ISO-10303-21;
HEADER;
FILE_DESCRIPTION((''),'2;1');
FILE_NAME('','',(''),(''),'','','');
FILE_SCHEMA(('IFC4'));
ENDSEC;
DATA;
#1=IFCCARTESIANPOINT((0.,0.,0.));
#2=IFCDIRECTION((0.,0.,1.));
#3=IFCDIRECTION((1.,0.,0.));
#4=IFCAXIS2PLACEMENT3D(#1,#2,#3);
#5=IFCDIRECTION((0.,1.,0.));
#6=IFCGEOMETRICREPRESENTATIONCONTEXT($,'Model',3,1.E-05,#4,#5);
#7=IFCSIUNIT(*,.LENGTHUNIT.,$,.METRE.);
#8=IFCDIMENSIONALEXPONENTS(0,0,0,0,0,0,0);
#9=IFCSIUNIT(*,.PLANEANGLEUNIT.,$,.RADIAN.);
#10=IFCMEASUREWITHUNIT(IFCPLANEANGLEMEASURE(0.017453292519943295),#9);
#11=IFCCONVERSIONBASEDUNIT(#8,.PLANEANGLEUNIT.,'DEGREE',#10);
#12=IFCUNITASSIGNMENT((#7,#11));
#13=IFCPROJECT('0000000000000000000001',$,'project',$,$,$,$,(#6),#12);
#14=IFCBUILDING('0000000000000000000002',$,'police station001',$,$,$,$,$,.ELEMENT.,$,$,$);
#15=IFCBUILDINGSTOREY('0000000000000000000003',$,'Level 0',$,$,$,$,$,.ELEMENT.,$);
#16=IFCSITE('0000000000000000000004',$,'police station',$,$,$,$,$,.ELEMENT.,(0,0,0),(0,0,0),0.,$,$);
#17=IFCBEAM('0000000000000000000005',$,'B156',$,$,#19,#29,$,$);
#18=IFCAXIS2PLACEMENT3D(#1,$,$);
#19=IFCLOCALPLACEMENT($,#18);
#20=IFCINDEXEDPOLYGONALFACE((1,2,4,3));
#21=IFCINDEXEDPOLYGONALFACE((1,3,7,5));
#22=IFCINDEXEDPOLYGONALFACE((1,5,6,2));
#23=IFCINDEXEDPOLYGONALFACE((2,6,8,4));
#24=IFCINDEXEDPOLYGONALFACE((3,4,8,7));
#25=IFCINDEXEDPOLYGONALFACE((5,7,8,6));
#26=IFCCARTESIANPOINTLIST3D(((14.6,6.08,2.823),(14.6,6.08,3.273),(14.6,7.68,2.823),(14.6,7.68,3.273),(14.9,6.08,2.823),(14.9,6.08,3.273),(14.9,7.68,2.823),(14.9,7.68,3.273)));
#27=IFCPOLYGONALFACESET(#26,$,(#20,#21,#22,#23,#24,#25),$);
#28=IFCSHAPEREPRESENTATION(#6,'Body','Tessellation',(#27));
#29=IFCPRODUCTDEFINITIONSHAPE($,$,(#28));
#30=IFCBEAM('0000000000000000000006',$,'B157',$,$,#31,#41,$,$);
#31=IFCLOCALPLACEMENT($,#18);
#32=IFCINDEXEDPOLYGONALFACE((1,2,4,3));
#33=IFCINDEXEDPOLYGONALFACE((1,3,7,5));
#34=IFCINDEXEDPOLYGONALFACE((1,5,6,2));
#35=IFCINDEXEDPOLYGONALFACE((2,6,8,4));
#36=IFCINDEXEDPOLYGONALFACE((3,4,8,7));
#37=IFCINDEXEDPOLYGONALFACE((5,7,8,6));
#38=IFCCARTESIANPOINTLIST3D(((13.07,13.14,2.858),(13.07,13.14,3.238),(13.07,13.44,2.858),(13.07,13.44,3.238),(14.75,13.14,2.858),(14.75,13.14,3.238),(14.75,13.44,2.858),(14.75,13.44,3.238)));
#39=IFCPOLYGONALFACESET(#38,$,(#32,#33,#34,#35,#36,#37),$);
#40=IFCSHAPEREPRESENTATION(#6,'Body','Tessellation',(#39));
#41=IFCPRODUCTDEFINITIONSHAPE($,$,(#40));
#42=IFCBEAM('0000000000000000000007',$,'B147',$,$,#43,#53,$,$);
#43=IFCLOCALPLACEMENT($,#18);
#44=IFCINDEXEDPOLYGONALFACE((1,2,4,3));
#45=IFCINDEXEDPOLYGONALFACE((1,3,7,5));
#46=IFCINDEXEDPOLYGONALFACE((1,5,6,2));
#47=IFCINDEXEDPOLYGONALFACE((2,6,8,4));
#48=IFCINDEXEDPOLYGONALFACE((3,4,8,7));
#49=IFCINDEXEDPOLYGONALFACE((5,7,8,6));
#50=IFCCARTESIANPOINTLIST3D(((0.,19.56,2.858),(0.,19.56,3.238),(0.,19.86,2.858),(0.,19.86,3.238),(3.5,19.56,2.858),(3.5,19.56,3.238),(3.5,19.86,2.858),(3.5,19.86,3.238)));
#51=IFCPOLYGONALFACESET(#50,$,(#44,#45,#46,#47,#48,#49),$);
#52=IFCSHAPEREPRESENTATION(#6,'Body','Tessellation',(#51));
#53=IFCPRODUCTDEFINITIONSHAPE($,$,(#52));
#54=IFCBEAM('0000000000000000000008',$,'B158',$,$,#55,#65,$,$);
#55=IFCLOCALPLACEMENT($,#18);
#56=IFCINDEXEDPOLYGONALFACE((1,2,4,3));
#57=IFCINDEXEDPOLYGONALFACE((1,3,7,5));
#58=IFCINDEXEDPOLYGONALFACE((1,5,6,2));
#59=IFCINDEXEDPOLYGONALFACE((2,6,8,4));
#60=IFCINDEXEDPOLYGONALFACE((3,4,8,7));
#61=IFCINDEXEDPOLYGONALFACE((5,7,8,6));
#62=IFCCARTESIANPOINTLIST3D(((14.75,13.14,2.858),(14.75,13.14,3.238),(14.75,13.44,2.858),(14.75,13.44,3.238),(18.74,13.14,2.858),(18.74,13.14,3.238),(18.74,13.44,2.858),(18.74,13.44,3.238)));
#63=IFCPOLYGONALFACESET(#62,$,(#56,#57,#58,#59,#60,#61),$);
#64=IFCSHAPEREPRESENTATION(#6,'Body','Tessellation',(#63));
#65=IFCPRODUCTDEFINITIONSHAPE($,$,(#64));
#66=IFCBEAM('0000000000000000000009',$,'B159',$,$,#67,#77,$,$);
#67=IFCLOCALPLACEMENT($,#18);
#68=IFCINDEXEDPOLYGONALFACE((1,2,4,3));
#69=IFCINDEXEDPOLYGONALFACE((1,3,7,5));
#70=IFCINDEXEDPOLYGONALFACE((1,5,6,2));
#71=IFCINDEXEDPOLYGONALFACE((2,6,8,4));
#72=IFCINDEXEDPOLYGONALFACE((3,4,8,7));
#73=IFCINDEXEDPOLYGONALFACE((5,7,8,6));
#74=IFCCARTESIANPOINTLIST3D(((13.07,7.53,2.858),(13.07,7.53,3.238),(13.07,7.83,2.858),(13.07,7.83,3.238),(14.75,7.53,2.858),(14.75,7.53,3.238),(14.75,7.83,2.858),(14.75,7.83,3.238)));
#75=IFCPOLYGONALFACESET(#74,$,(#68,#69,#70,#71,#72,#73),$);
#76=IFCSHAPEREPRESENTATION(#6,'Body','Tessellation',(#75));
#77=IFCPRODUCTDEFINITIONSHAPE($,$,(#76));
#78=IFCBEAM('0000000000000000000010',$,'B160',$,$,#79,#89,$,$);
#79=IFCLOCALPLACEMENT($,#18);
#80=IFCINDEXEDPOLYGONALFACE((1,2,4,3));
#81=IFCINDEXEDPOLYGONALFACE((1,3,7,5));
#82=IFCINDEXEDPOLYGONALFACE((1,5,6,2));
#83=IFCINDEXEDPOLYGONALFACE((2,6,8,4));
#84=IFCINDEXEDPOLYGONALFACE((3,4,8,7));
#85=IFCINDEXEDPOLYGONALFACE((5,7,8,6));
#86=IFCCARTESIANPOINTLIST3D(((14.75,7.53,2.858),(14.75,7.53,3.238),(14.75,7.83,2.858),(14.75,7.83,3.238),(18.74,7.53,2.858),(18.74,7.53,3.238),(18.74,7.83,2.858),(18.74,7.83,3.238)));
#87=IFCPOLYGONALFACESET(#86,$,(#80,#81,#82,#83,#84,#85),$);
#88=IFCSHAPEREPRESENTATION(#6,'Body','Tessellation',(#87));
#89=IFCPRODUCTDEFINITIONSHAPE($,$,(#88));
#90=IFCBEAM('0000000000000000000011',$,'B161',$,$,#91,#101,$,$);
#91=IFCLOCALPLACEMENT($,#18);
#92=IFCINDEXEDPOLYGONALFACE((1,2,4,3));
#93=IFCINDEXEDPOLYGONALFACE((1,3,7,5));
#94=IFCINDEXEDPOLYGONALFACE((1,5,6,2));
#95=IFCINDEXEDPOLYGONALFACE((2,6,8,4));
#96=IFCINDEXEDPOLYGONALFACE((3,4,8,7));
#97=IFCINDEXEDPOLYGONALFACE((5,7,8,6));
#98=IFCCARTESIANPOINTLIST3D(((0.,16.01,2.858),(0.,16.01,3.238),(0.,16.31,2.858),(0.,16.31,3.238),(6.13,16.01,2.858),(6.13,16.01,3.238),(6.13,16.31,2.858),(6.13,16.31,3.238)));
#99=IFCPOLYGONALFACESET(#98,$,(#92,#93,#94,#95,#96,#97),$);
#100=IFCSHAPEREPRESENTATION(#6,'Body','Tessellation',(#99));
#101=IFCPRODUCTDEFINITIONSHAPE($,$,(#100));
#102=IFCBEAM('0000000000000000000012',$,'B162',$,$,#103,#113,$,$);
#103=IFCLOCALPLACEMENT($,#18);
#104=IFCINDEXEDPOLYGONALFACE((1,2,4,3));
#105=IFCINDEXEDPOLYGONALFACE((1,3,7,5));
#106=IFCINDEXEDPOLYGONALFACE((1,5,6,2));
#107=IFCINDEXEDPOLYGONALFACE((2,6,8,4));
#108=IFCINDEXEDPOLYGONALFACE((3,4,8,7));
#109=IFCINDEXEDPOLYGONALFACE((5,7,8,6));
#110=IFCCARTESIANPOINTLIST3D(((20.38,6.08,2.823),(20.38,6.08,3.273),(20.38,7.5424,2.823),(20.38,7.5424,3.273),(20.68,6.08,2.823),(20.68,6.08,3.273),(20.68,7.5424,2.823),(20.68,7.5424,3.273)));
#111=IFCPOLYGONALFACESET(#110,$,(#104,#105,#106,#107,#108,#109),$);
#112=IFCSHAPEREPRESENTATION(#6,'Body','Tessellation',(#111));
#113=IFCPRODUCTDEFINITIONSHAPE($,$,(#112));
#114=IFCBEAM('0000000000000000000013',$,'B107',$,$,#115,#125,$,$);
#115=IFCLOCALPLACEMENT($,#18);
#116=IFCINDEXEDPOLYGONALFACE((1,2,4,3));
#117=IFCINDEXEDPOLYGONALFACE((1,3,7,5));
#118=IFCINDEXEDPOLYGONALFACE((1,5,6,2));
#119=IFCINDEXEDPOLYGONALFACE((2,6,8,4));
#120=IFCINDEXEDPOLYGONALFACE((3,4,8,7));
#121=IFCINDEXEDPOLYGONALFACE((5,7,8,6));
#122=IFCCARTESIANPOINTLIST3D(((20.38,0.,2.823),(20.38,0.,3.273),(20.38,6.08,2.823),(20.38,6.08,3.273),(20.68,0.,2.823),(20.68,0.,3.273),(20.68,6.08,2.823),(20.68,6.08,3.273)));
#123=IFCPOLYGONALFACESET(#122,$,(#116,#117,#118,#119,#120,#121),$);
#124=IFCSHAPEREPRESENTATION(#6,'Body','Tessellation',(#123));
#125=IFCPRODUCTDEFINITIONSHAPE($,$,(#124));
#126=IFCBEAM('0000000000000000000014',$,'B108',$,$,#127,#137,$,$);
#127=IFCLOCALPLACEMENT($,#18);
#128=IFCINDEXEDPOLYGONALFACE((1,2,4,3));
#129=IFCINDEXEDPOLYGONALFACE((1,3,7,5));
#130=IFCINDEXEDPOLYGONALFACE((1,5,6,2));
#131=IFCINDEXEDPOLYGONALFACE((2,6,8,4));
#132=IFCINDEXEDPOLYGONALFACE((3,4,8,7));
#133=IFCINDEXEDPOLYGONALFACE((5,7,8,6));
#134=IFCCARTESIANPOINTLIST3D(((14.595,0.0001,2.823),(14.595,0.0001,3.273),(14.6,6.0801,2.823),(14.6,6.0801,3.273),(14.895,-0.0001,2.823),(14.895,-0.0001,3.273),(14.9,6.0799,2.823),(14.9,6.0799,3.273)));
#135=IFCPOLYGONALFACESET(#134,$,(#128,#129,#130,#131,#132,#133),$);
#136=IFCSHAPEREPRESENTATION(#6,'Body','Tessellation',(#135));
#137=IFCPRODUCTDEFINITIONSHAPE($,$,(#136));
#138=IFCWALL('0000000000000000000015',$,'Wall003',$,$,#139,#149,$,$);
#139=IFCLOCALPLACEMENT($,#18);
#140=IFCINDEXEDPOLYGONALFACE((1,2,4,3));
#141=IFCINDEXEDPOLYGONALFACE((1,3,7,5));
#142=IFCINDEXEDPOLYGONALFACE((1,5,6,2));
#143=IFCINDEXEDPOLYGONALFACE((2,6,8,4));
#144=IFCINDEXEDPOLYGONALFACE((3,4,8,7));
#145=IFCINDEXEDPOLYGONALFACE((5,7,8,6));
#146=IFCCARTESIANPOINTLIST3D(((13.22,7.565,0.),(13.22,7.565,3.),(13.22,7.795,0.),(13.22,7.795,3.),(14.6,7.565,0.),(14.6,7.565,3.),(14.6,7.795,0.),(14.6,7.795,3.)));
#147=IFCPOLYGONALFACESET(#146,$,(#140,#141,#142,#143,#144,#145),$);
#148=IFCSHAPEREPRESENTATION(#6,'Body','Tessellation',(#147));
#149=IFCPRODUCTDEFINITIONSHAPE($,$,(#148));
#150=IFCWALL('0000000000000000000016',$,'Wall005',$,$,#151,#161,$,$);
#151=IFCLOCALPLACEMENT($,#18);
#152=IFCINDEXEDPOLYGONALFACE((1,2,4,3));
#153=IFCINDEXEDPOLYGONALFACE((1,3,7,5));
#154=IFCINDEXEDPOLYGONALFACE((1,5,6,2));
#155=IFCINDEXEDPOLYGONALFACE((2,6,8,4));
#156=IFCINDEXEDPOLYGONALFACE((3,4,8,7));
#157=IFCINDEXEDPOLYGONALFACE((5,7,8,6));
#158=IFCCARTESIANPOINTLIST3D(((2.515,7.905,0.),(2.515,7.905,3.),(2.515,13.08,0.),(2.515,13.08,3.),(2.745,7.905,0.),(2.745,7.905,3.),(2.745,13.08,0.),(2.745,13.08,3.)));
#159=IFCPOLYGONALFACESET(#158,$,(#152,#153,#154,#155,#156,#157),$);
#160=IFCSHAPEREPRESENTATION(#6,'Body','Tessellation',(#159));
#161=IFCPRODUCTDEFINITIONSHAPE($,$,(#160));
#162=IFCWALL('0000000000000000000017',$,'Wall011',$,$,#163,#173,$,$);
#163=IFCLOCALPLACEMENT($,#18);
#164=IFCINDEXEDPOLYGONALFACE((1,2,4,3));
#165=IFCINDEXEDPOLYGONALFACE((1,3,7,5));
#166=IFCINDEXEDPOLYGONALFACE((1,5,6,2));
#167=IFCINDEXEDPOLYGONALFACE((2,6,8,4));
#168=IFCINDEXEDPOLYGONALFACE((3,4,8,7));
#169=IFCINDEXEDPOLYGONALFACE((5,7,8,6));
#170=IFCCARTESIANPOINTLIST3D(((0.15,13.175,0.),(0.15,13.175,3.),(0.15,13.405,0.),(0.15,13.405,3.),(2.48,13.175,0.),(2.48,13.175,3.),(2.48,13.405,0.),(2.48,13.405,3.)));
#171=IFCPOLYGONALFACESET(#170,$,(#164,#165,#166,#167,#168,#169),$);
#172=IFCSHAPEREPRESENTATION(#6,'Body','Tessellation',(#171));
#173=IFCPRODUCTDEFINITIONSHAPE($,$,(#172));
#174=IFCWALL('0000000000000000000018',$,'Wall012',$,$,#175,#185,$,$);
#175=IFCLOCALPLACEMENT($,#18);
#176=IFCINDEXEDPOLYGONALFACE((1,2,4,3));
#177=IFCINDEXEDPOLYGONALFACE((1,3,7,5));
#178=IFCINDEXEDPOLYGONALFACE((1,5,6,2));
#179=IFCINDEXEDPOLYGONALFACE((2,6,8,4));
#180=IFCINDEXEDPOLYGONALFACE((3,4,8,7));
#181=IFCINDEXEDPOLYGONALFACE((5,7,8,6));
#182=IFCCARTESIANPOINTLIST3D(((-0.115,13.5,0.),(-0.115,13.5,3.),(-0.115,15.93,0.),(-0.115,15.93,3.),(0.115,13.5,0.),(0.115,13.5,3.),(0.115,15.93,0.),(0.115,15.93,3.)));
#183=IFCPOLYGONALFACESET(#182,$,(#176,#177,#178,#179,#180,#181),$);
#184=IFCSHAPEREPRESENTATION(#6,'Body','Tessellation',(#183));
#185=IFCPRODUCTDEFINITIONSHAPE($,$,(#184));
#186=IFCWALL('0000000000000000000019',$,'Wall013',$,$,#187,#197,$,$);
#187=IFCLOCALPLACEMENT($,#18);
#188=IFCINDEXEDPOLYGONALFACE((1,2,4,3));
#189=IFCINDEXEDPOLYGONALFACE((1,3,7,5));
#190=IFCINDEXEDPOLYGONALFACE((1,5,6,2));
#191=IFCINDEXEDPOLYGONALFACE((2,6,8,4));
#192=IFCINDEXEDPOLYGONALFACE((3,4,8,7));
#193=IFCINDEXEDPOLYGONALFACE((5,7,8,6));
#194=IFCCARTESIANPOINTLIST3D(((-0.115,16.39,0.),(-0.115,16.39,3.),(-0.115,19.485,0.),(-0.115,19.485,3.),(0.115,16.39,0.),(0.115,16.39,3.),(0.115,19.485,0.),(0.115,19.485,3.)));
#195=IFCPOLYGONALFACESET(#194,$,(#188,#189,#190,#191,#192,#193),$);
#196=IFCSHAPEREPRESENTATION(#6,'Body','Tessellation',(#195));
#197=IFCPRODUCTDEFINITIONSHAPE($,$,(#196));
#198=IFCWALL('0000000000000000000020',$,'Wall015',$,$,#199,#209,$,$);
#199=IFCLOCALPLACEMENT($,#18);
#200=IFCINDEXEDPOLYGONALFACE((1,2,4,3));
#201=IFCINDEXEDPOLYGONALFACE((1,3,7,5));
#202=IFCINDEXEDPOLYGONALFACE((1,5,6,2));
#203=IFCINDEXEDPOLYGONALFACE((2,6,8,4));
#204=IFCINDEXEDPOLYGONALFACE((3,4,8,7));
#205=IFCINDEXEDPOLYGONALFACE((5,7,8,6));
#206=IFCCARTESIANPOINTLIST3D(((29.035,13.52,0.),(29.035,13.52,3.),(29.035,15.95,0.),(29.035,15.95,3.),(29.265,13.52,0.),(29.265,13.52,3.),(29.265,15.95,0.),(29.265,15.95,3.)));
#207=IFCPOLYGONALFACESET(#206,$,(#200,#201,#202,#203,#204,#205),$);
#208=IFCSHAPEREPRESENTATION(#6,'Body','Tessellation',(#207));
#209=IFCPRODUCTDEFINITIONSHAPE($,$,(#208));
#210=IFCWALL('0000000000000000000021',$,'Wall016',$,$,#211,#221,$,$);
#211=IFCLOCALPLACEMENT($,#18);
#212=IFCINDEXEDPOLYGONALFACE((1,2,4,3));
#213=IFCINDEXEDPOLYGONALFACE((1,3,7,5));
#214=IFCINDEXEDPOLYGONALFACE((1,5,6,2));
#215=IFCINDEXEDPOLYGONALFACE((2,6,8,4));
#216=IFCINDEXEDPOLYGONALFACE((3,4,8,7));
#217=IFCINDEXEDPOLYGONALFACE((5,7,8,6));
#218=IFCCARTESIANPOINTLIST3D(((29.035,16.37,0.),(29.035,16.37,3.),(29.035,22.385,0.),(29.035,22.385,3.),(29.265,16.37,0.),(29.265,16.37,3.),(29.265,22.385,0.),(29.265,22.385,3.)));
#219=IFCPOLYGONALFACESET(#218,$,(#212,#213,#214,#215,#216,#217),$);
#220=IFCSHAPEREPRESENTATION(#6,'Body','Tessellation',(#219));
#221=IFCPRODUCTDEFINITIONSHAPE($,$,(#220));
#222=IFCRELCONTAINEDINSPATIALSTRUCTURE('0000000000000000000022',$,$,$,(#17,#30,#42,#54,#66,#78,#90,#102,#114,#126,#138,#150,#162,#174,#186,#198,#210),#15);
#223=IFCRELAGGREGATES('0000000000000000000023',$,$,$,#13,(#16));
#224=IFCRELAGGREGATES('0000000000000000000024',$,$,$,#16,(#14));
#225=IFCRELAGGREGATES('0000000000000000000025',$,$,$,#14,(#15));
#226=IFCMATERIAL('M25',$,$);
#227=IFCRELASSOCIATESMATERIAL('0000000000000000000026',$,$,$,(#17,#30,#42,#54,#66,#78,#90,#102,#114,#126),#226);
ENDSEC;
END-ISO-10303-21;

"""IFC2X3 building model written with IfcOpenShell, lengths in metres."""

from ifc_helpers import new_model, entity, si_unit, converted_unit, direction, frame, frame_2d, origin_with_axes, place, context, project, spatial, rectangle, extrude, material, element, save


model = new_model("IFC2X3")

# Units and contexts
model_context = context("Model", 3, precision=1e-05, world=origin_with_axes(), true_north=direction((0.0, 1.0, 0.0)))
ifc_project = project(units=[si_unit("LENGTHUNIT", "METRE"), converted_unit("PLANEANGLEUNIT", "DEGREE", entity("IfcPlaneAngleMeasure", 0.017453292519943295), si_unit("PLANEANGLEUNIT", "RADIAN"), dimensions=[0, 0, 0, 0, 0, 0, 0])], contexts=[model_context])

# Site, building, storey
site = spatial("IfcSite", under=ifc_project, Name="police station", CompositionType="ELEMENT", RefLatitude=(0, 0, 0), RefLongitude=(0, 0, 0), RefElevation=0.0)
building = spatial("IfcBuilding", under=site, Name="police station001", CompositionType="ELEMENT")
storey = spatial("IfcBuildingStorey", under=building, Name="Level 0", CompositionType="ELEMENT")

# Beams
ifc_material = material(Name="M25")
placement = place(None, origin_with_axes())
element("IfcBeam", 1, at=placement, inside=storey, material=ifc_material, Name="B156", context=model_context, shape_type="SweptSolid", body=[
    extrude(rectangle(XDim=0.3, YDim=0.45, at=frame_2d((0.0, 0.0), x_axis=(0.0, 1.0, 0.0))), frame((14.75, 6.08, 3.048), z_axis=(0.0, 1.0, 0.0), x_axis=(0.0, 0.0, -1.0)), (0.0, 0.0, 1.0), 1.6),
])
element("IfcBeam", 2, at=placement, inside=storey, material=ifc_material, Name="B157", context=model_context, shape_type="SweptSolid", body=[
    extrude(rectangle(XDim=0.3, YDim=0.38, at=frame_2d((0.0, 0.0), x_axis=(0.0, 1.0, 0.0))), frame((13.07, 13.29, 3.048), z_axis=(1.0, 0.0, 0.0), x_axis=(0.0, 0.0, -1.0)), (0.0, 0.0, 1.0), 1.68),
])
element("IfcBeam", 3, at=placement, inside=storey, material=ifc_material, Name="B147", context=model_context, shape_type="SweptSolid", body=[
    extrude(rectangle(XDim=0.3, YDim=0.38, at=frame_2d((0.0, 0.0), x_axis=(0.0, 1.0, 0.0))), frame((0.0, 19.71, 3.048), z_axis=(1.0, 0.0, 0.0), x_axis=(0.0, 0.0, -1.0)), (0.0, 0.0, 1.0), 3.5),
])
element("IfcBeam", 4, at=placement, inside=storey, material=ifc_material, Name="B158", context=model_context, shape_type="SweptSolid", body=[
    extrude(rectangle(XDim=0.3, YDim=0.38, at=frame_2d((0.0, 0.0), x_axis=(0.0, 1.0, 0.0))), frame((14.75, 13.29, 3.048), z_axis=(1.0, 0.0, 0.0), x_axis=(0.0, 0.0, -1.0)), (0.0, 0.0, 1.0), 3.99),
])
element("IfcBeam", 5, at=placement, inside=storey, material=ifc_material, Name="B159", context=model_context, shape_type="SweptSolid", body=[
    extrude(rectangle(XDim=0.3, YDim=0.38, at=frame_2d((0.0, 0.0), x_axis=(0.0, 1.0, 0.0))), frame((13.07, 7.68, 3.048), z_axis=(1.0, 0.0, 0.0), x_axis=(0.0, 0.0, -1.0)), (0.0, 0.0, 1.0), 1.68),
])
element("IfcBeam", 6, at=placement, inside=storey, material=ifc_material, Name="B160", context=model_context, shape_type="SweptSolid", body=[
    extrude(rectangle(XDim=0.3, YDim=0.38, at=frame_2d((0.0, 0.0), x_axis=(0.0, 1.0, 0.0))), frame((14.75, 7.68, 3.048), z_axis=(1.0, 0.0, 0.0), x_axis=(0.0, 0.0, -1.0)), (0.0, 0.0, 1.0), 3.99),
])
element("IfcBeam", 7, at=placement, inside=storey, material=ifc_material, Name="B161", context=model_context, shape_type="SweptSolid", body=[
    extrude(rectangle(XDim=0.3, YDim=0.38, at=frame_2d((0.0, 0.0), x_axis=(0.0, 1.0, 0.0))), frame((6.13, 16.16, 3.048), z_axis=(-1.0, 0.0, 0.0), x_axis=(0.0, 0.0, -1.0)), (0.0, 0.0, 1.0), 6.13),
])
element("IfcBeam", 8, at=placement, inside=storey, material=ifc_material, Name="B162", context=model_context, shape_type="SweptSolid", body=[
    extrude(rectangle(XDim=0.3, YDim=0.45, at=frame_2d((0.0, 0.0), x_axis=(0.0, 1.0, 0.0))), frame((20.53, 6.08, 3.048), z_axis=(0.0, 1.0, 0.0), x_axis=(0.0, 0.0, -1.0)), (0.0, 0.0, 1.0), 1.4624),
])
element("IfcBeam", 9, at=placement, inside=storey, material=ifc_material, Name="B107", context=model_context, shape_type="SweptSolid", body=[
    extrude(rectangle(XDim=0.3, YDim=0.45, at=frame_2d((0.0, 0.0), x_axis=(0.0, 1.0, 0.0))), frame((20.53, 0.0, 3.048), z_axis=(0.0, 1.0, 0.0), x_axis=(0.0, 0.0, -1.0)), (0.0, 0.0, 1.0), 6.08),
])
element("IfcBeam", 10, at=placement, inside=storey, material=ifc_material, Name="B108", context=model_context, shape_type="SweptSolid", body=[
    extrude(rectangle(XDim=0.3, YDim=0.45, at=frame_2d((0.0, 0.0), x_axis=(0.0, 1.0, 0.0))), frame((14.745, 0.0, 3.048), z_axis=(0.000822, 1.0, 0.0), x_axis=(0.0, 0.0, -1.0)), (0.0, 0.0, 1.0), 6.08),
])

# Walls
element("IfcWall", 11, at=placement, inside=storey, Name="Wall003", context=model_context, shape_type="SweptSolid", body=[
    extrude(rectangle(XDim=1.38, YDim=0.23, at=frame_2d((0.0, 0.0), x_axis=(1.0, 0.0, 0.0))), frame((13.91, 7.68, 0.0), z_axis=(0.0, 0.0, 1.0), x_axis=(1.0, 0.0, 0.0)), (0.0, 0.0, 1.0), 3.0),
])
element("IfcWall", 12, at=placement, inside=storey, Name="Wall005", context=model_context, shape_type="SweptSolid", body=[
    extrude(rectangle(XDim=5.175, YDim=0.23, at=frame_2d((0.0, 0.0), x_axis=(0.0, -1.0, 0.0))), frame((2.63, 10.4925, 0.0), z_axis=(0.0, 0.0, 1.0), x_axis=(1.0, 0.0, 0.0)), (0.0, 0.0, 1.0), 3.0),
])
element("IfcWall", 13, at=placement, inside=storey, Name="Wall011", context=model_context, shape_type="SweptSolid", body=[
    extrude(rectangle(XDim=2.33, YDim=0.23, at=frame_2d((0.0, 0.0), x_axis=(1.0, 0.0, 0.0))), frame((1.315, 13.29, 0.0), z_axis=(0.0, 0.0, 1.0), x_axis=(1.0, 0.0, 0.0)), (0.0, 0.0, 1.0), 3.0),
])
element("IfcWall", 14, at=placement, inside=storey, Name="Wall012", context=model_context, shape_type="SweptSolid", body=[
    extrude(rectangle(XDim=2.43, YDim=0.23, at=frame_2d((0.0, 0.0), x_axis=(0.0, -1.0, 0.0))), frame((0.0, 14.715, 0.0), z_axis=(0.0, 0.0, 1.0), x_axis=(1.0, 0.0, 0.0)), (0.0, 0.0, 1.0), 3.0),
])
element("IfcWall", 15, at=placement, inside=storey, Name="Wall013", context=model_context, shape_type="SweptSolid", body=[
    extrude(rectangle(XDim=3.095, YDim=0.23, at=frame_2d((0.0, 0.0), x_axis=(0.0, -1.0, 0.0))), frame((0.0, 17.9375, 0.0), z_axis=(0.0, 0.0, 1.0), x_axis=(1.0, 0.0, 0.0)), (0.0, 0.0, 1.0), 3.0),
])
element("IfcWall", 16, at=placement, inside=storey, Name="Wall015", context=model_context, shape_type="SweptSolid", body=[
    extrude(rectangle(XDim=2.43, YDim=0.23, at=frame_2d((0.0, 0.0), x_axis=(0.0, -1.0, 0.0))), frame((29.15, 14.735, 0.0), z_axis=(0.0, 0.0, 1.0), x_axis=(1.0, 0.0, 0.0)), (0.0, 0.0, 1.0), 3.0),
])
element("IfcWall", 17, at=placement, inside=storey, Name="Wall016", context=model_context, shape_type="SweptSolid", body=[
    extrude(rectangle(XDim=6.015, YDim=0.23, at=frame_2d((0.0, 0.0), x_axis=(0.0, 1.0, 0.0))), frame((29.15, 19.3775, 0.0), z_axis=(0.0, 0.0, 1.0), x_axis=(1.0, 0.0, 0.0)), (0.0, 0.0, 1.0), 3.0),
])

save(model, "model.ifc")
